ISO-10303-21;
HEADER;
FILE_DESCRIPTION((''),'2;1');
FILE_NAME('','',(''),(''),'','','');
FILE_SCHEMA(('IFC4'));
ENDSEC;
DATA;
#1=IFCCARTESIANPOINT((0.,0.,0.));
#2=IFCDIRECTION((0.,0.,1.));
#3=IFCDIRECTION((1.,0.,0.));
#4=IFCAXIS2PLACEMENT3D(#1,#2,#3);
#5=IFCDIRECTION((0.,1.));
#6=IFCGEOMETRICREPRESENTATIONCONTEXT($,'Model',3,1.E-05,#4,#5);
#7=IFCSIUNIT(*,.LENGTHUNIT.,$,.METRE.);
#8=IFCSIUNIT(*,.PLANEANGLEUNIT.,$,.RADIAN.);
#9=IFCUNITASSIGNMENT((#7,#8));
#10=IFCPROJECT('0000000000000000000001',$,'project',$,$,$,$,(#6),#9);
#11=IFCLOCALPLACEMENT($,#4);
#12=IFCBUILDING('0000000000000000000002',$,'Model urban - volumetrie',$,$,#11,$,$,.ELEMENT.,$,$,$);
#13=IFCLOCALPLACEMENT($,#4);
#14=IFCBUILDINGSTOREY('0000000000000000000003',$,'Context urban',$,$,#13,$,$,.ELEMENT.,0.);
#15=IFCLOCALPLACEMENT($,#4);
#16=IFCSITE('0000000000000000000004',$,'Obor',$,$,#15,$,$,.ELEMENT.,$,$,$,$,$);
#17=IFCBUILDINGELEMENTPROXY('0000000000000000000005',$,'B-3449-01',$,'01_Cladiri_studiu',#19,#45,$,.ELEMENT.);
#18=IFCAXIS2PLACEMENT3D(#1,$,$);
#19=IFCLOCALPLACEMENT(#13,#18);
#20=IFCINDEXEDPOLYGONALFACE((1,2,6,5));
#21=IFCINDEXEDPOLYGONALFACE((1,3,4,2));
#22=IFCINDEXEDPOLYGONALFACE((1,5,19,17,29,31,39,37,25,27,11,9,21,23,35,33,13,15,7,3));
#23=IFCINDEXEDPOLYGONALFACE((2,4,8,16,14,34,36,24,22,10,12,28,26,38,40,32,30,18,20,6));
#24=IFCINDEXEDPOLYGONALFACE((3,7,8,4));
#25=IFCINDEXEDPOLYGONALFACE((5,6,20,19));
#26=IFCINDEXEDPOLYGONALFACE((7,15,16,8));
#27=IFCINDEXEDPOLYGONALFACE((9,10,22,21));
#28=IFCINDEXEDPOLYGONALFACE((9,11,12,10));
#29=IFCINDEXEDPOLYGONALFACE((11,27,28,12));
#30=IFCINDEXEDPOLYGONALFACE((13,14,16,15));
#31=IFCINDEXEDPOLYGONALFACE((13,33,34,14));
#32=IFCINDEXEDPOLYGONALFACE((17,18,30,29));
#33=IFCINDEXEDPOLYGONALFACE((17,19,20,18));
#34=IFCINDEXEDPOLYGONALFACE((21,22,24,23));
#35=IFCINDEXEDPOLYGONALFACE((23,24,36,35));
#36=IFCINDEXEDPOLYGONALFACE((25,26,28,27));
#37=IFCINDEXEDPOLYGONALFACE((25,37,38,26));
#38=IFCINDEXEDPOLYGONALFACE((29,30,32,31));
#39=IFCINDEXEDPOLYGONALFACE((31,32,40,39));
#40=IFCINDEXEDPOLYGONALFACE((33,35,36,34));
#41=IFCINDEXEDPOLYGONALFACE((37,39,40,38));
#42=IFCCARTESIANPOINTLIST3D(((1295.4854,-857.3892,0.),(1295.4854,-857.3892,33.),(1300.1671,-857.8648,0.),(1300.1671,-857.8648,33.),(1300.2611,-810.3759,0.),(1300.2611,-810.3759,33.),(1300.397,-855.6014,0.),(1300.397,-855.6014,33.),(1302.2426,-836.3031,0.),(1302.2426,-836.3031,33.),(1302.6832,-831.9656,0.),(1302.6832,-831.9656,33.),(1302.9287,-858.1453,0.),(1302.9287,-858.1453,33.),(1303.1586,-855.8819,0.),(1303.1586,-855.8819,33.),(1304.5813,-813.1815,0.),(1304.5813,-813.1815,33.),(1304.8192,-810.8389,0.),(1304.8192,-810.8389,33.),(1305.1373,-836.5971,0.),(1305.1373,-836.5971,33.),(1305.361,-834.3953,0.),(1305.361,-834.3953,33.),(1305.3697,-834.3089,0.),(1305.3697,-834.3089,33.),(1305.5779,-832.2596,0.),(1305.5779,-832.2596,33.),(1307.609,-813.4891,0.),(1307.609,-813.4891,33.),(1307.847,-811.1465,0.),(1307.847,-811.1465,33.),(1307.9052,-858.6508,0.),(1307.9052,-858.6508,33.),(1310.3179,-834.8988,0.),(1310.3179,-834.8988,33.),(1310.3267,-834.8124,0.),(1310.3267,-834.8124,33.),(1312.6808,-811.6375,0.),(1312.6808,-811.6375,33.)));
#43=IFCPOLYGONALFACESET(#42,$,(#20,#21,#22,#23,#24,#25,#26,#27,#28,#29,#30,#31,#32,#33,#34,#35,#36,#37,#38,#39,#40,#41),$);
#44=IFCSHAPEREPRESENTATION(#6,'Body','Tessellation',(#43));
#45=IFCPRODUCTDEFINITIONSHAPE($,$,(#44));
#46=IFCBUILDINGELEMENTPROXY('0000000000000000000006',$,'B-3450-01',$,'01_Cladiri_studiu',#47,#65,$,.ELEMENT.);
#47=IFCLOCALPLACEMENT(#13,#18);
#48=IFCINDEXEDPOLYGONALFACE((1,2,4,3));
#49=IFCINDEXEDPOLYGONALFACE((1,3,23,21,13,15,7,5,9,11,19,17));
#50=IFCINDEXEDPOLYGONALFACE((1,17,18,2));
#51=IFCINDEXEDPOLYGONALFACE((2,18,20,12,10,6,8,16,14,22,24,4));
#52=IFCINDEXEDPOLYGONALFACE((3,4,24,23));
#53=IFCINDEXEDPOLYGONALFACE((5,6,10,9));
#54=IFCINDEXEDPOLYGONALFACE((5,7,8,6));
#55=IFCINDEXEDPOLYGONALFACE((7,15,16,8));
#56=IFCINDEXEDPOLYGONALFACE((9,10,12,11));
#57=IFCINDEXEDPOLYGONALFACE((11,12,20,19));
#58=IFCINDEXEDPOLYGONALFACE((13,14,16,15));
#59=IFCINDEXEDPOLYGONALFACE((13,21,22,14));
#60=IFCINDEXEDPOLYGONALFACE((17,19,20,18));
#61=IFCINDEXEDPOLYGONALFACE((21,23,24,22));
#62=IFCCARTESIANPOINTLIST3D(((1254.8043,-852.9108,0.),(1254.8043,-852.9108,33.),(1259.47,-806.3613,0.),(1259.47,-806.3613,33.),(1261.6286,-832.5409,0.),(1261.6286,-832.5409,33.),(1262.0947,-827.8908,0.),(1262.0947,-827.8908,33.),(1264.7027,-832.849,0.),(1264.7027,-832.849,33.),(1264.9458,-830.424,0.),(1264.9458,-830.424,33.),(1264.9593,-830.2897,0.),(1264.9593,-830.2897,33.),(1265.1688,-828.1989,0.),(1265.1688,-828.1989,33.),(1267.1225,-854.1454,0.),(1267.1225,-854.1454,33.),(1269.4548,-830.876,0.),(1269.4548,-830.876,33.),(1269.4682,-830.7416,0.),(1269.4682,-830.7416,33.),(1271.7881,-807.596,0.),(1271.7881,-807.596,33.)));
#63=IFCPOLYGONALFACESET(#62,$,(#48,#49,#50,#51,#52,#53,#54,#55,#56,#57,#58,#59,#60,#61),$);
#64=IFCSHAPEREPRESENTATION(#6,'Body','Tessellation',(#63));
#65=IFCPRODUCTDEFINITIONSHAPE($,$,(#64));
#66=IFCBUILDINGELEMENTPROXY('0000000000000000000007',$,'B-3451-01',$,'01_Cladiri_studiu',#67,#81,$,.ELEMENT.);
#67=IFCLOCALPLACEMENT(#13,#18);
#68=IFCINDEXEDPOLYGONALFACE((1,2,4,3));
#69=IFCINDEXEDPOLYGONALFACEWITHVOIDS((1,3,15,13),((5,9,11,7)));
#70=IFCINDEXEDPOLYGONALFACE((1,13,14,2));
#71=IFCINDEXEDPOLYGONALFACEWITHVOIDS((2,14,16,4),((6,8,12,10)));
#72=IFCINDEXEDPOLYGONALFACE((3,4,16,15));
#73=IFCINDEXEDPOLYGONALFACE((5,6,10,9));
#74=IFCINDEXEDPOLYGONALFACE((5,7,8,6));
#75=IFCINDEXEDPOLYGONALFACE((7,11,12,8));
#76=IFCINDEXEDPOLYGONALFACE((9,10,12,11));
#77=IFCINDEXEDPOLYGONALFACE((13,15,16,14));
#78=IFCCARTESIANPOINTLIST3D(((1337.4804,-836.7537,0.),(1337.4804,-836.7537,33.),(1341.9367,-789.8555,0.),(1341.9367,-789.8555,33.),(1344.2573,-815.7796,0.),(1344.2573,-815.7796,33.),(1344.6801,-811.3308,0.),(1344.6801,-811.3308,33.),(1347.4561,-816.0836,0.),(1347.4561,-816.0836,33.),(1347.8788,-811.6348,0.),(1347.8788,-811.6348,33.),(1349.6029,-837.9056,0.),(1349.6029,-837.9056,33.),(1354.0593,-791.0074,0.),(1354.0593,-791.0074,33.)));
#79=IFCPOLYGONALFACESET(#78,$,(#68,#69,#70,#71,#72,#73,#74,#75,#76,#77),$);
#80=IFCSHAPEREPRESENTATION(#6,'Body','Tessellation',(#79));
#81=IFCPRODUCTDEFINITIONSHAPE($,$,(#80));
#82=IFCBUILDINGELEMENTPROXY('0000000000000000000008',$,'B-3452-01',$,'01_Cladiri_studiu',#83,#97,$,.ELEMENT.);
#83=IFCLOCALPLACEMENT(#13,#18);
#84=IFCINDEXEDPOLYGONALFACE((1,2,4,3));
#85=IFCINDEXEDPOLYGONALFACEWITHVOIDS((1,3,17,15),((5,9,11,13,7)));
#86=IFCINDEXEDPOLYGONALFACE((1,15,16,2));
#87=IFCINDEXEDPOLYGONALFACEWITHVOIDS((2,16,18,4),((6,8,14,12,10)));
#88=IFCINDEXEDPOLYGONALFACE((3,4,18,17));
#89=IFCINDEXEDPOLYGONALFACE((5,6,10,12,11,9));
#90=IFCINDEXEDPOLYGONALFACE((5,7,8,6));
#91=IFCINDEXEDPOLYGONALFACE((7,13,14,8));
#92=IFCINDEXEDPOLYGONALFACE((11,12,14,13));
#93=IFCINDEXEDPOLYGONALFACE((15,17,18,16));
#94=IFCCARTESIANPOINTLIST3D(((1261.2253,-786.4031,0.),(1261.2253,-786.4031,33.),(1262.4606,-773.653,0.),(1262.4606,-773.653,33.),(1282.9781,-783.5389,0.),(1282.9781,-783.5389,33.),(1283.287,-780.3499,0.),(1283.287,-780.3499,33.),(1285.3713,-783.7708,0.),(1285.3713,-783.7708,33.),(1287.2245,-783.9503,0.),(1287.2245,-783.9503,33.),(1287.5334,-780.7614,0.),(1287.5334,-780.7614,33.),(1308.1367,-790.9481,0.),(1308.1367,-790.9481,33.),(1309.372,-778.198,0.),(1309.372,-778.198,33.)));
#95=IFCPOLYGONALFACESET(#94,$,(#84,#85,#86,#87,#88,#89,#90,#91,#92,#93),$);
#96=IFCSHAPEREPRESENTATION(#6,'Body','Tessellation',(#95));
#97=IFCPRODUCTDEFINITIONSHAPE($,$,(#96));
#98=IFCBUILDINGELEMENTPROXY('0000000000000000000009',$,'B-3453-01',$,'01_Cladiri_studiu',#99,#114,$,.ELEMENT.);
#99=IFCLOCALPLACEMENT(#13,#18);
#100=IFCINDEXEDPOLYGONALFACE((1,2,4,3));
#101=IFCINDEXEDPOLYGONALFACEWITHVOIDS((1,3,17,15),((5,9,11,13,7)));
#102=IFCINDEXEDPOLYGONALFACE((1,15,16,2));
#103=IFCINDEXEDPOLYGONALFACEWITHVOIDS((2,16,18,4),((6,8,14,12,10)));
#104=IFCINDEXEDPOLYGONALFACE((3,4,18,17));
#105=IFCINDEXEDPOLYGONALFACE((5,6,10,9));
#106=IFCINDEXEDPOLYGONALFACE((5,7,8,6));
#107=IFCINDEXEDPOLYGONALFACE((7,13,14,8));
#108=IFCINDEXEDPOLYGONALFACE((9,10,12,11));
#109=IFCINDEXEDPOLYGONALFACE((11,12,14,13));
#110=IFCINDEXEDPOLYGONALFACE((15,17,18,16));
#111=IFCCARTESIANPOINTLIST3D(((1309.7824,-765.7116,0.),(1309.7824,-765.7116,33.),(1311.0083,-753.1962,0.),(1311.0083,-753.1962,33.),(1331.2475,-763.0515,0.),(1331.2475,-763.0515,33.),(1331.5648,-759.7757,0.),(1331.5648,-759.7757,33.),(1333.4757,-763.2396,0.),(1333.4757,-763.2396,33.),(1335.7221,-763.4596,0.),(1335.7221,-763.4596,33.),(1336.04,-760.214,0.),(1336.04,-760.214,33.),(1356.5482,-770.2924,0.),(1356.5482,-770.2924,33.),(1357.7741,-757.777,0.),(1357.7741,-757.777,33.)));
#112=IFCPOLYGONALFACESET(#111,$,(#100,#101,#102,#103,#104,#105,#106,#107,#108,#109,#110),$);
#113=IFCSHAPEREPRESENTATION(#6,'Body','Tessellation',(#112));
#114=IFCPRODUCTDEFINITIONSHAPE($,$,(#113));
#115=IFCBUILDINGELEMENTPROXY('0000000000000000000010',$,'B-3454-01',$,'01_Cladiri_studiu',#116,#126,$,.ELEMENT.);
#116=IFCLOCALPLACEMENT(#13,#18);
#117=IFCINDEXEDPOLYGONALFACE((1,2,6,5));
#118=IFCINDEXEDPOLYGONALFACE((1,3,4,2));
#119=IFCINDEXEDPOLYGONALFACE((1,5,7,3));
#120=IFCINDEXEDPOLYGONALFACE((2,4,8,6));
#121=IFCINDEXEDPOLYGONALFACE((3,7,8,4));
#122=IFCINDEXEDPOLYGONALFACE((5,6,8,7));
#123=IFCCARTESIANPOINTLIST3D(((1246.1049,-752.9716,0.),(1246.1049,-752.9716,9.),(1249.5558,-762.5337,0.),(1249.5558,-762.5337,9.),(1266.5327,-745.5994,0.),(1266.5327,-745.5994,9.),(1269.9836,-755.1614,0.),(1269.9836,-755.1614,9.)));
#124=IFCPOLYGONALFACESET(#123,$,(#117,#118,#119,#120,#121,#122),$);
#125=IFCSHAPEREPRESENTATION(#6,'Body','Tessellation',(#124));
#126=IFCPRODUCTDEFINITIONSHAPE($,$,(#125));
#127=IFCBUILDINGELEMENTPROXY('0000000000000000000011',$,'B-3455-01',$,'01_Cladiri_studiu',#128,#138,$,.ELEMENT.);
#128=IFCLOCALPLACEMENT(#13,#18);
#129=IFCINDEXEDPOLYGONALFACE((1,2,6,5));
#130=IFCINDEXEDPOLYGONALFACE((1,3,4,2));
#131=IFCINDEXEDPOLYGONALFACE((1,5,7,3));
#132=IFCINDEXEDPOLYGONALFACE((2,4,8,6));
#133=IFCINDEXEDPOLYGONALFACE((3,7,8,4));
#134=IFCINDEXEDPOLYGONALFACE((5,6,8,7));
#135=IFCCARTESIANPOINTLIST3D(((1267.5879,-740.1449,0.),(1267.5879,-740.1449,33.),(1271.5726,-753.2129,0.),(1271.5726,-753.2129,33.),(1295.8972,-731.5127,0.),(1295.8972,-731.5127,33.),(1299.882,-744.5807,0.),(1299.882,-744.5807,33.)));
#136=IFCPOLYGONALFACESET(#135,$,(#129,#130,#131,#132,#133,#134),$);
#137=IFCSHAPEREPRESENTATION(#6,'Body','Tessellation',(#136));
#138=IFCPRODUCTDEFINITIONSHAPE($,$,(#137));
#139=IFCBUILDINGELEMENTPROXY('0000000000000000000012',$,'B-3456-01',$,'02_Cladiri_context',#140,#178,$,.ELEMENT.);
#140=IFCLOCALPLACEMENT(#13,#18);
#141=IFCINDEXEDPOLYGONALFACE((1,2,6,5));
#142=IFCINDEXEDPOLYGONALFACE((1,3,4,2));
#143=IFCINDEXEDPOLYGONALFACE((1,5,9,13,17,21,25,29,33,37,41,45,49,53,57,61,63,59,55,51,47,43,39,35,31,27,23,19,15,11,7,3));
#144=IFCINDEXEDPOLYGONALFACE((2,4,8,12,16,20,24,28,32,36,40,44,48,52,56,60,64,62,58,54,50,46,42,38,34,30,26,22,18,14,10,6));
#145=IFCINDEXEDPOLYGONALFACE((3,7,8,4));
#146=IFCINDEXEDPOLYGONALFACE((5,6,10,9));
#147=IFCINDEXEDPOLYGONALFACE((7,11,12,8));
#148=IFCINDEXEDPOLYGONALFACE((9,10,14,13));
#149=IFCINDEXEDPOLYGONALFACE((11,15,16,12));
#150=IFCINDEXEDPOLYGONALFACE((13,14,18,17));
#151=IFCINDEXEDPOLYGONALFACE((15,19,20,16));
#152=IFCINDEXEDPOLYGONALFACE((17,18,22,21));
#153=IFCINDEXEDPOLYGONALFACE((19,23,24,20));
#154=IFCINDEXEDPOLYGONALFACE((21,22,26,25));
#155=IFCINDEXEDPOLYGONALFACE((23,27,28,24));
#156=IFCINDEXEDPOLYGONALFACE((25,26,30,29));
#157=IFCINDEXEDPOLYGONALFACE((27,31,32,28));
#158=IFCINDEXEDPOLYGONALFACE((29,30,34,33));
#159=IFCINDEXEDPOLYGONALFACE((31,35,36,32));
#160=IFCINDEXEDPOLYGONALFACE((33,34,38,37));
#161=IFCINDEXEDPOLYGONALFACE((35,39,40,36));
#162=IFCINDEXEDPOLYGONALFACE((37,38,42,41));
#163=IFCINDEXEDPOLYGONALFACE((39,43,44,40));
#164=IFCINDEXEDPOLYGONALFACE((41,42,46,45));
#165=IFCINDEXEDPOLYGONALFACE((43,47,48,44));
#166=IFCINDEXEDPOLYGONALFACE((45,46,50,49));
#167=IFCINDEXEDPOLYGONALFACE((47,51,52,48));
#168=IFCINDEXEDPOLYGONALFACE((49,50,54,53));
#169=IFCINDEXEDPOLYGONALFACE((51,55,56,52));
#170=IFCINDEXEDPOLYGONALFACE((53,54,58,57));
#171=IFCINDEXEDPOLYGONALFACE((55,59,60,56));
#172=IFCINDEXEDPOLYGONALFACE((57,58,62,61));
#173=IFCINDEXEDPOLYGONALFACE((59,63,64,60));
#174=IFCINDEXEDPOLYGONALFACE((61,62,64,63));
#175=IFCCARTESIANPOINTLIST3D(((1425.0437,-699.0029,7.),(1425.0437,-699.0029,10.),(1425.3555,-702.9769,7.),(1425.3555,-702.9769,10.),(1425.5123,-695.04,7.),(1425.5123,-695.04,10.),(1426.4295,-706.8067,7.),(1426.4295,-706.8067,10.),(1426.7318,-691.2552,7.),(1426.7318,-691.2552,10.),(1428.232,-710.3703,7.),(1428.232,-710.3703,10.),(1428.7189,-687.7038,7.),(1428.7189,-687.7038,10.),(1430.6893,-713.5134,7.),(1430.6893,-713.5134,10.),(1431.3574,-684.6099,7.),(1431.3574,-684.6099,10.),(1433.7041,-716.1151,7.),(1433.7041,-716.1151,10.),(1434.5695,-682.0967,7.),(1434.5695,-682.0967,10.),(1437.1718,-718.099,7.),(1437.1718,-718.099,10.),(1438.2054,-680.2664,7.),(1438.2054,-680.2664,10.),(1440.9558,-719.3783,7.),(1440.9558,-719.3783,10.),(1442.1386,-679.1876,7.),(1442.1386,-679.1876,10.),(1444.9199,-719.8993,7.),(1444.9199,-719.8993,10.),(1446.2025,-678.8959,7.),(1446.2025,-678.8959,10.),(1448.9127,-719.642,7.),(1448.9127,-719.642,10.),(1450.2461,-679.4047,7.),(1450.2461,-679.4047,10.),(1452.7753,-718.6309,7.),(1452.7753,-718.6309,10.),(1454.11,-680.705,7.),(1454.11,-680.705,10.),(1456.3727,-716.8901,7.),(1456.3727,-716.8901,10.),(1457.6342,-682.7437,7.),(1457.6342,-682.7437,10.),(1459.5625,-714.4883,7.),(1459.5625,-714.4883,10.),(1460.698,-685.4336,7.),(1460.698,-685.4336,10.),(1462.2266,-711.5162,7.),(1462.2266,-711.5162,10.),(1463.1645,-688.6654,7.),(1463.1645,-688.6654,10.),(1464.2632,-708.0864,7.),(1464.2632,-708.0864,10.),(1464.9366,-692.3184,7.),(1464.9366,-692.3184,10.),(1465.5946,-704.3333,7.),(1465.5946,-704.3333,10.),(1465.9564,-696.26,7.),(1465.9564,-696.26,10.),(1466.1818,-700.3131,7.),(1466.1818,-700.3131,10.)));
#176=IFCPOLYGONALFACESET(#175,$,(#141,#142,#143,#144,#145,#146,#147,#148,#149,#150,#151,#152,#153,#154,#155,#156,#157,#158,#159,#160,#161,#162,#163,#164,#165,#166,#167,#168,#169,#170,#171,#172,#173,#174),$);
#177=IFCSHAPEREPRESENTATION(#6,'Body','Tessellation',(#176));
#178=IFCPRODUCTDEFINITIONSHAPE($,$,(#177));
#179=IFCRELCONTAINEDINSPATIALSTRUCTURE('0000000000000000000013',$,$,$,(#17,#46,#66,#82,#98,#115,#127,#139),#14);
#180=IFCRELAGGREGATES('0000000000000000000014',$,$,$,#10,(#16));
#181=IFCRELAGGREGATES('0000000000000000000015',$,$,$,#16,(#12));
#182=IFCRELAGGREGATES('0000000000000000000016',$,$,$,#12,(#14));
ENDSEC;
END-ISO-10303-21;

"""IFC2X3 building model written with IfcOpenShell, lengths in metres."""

from ifc_helpers import new_model, si_unit, direction, frame, origin_with_axes, place, context, project, spatial, polyline, outline, extrude, element, save


model = new_model("IFC2X3")

# Units and contexts
model_context = context("Model", 3, precision=1e-05, world=origin_with_axes(), true_north=direction((0.0, 1.0)))
ifc_project = project(units=[si_unit("LENGTHUNIT", "METRE"), si_unit("PLANEANGLEUNIT", "RADIAN")], contexts=[model_context])

# Site, building, storey
site_placement = place(None, origin_with_axes())
site = spatial("IfcSite", under=ifc_project, at=site_placement, Name="Obor", CompositionType="ELEMENT")
building_placement = place(None, origin_with_axes())
building = spatial("IfcBuilding", under=site, at=building_placement, Name="Model urban - volumetrie", CompositionType="ELEMENT")
storey_placement = place(None, origin_with_axes())
storey = spatial("IfcBuildingStorey", under=building, at=storey_placement, Name="Context urban", CompositionType="ELEMENT", Elevation=0.0)

# Building element proxies
proxy_1_placement = place(None, origin_with_axes())
element("IfcBuildingElementProxy", 1, at=proxy_1_placement, inside=storey, Name="B-3449-01", ObjectType="01_Cladiri_studiu", CompositionType="ELEMENT", context=model_context, shape_type="SweptSolid", body=[
    extrude(outline(polyline([(1304.8192, -810.8389), (1300.2611, -810.3759), (1295.4854, -857.3892), (1300.1671, -857.8648), (1300.397, -855.6014), (1303.1586, -855.8819), (1302.9287, -858.1453), (1307.9052, -858.6508), (1310.3179, -834.8988), (1305.361, -834.3953), (1305.1373, -836.5971), (1302.2426, -836.3031), (1302.6832, -831.9656), (1305.5779, -832.2596), (1305.3697, -834.3089), (1310.3267, -834.8124), (1312.6808, -811.6375), (1307.847, -811.1465), (1307.609, -813.4891), (1304.5813, -813.1815), (1304.8192, -810.8389)])), origin_with_axes(), (0.0, 0.0, 1.0), 33.0),
])
proxy_2_placement = place(None, origin_with_axes())
element("IfcBuildingElementProxy", 2, at=proxy_2_placement, inside=storey, Name="B-3450-01", ObjectType="01_Cladiri_studiu", CompositionType="ELEMENT", context=model_context, shape_type="SweptSolid", body=[
    extrude(outline(polyline([(1269.4548, -830.876), (1264.9458, -830.424), (1264.7027, -832.849), (1261.6286, -832.5409), (1262.0947, -827.8908), (1265.1688, -828.1989), (1264.9593, -830.2897), (1269.4682, -830.7416), (1271.7881, -807.596), (1259.47, -806.3613), (1254.8043, -852.9108), (1267.1225, -854.1454), (1269.4548, -830.876)])), origin_with_axes(), (0.0, 0.0, 1.0), 33.0),
])
proxy_3_placement = place(None, origin_with_axes())
element("IfcBuildingElementProxy", 3, at=proxy_3_placement, inside=storey, Name="B-3451-01", ObjectType="01_Cladiri_studiu", CompositionType="ELEMENT", context=model_context, shape_type="SweptSolid", body=[
    extrude(outline(polyline([(1354.0593, -791.0074), (1341.9367, -789.8555), (1337.4804, -836.7537), (1349.6029, -837.9056), (1354.0593, -791.0074)]), holes=[polyline([(1344.2573, -815.7796), (1344.6801, -811.3308), (1347.8788, -811.6348), (1347.4561, -816.0836), (1344.2573, -815.7796)])]), origin_with_axes(), (0.0, 0.0, 1.0), 33.0),
])
proxy_4_placement = place(None, origin_with_axes())
element("IfcBuildingElementProxy", 4, at=proxy_4_placement, inside=storey, Name="B-3452-01", ObjectType="01_Cladiri_studiu", CompositionType="ELEMENT", context=model_context, shape_type="SweptSolid", body=[
    extrude(outline(polyline([(1261.2253, -786.4031), (1308.1367, -790.9481), (1309.372, -778.198), (1262.4606, -773.653), (1261.2253, -786.4031)]), holes=[polyline([(1285.3713, -783.7708), (1282.9781, -783.5389), (1283.287, -780.3499), (1287.5334, -780.7614), (1287.2245, -783.9503), (1285.3713, -783.7708), (1285.3292, -784.2059), (1285.3713, -783.7708)])]), origin_with_axes(), (0.0, 0.0, 1.0), 33.0),
])
proxy_5_placement = place(None, origin_with_axes())
element("IfcBuildingElementProxy", 5, at=proxy_5_placement, inside=storey, Name="B-3453-01", ObjectType="01_Cladiri_studiu", CompositionType="ELEMENT", context=model_context, shape_type="SweptSolid", body=[
    extrude(outline(polyline([(1356.5482, -770.2924), (1357.7741, -757.777), (1311.0083, -753.1962), (1309.7824, -765.7116), (1356.5482, -770.2924)]), holes=[polyline([(1336.04, -760.214), (1335.7221, -763.4596), (1333.4757, -763.2396), (1331.2475, -763.0515), (1331.5648, -759.7757), (1336.04, -760.214)])]), origin_with_axes(), (0.0, 0.0, 1.0), 33.0),
])
proxy_6_placement = place(None, origin_with_axes())
element("IfcBuildingElementProxy", 6, at=proxy_6_placement, inside=storey, Name="B-3454-01", ObjectType="01_Cladiri_studiu", CompositionType="ELEMENT", context=model_context, shape_type="SweptSolid", body=[
    extrude(outline(polyline([(1269.9836, -755.1614), (1266.5327, -745.5994), (1246.1049, -752.9716), (1249.5558, -762.5337), (1269.9836, -755.1614)])), origin_with_axes(), (0.0, 0.0, 1.0), 9.0),
])
proxy_7_placement = place(None, origin_with_axes())
element("IfcBuildingElementProxy", 7, at=proxy_7_placement, inside=storey, Name="B-3455-01", ObjectType="01_Cladiri_studiu", CompositionType="ELEMENT", context=model_context, shape_type="SweptSolid", body=[
    extrude(outline(polyline([(1299.882, -744.5807), (1295.8972, -731.5127), (1267.5879, -740.1449), (1271.5726, -753.2129), (1299.882, -744.5807)])), origin_with_axes(), (0.0, 0.0, 1.0), 33.0),
])
proxy_8_placement = place(None, origin_with_axes())
element("IfcBuildingElementProxy", 8, at=proxy_8_placement, inside=storey, Name="B-3456-01", ObjectType="02_Cladiri_context", CompositionType="ELEMENT", context=model_context, shape_type="SweptSolid", body=[
    extrude(outline(polyline([(1428.232, -710.3703), (1430.6893, -713.5134), (1433.7041, -716.1151), (1437.1718, -718.099), (1440.9558, -719.3783), (1444.9199, -719.8993), (1448.9127, -719.642), (1452.7753, -718.6309), (1456.3727, -716.8901), (1459.5625, -714.4883), (1462.2266, -711.5162), (1464.2632, -708.0864), (1465.5946, -704.3333), (1466.1818, -700.3131), (1465.9564, -696.26), (1464.9366, -692.3184), (1463.1645, -688.6654), (1460.698, -685.4336), (1457.6342, -682.7437), (1454.11, -680.705), (1450.2461, -679.4047), (1446.2025, -678.8959), (1442.1386, -679.1876), (1438.2054, -680.2664), (1434.5695, -682.0967), (1431.3574, -684.6099), (1428.7189, -687.7038), (1426.7318, -691.2552), (1425.5123, -695.04), (1425.0437, -699.0029), (1425.3555, -702.9769), (1426.4295, -706.8067), (1428.232, -710.3703)])), frame((0.0, 0.0, 7.0), z_axis=(0.0, 0.0, 1.0), x_axis=(1.0, 0.0, 0.0)), (0.0, 0.0, 1.0), 3.0),
])

save(model, "model.ifc")
